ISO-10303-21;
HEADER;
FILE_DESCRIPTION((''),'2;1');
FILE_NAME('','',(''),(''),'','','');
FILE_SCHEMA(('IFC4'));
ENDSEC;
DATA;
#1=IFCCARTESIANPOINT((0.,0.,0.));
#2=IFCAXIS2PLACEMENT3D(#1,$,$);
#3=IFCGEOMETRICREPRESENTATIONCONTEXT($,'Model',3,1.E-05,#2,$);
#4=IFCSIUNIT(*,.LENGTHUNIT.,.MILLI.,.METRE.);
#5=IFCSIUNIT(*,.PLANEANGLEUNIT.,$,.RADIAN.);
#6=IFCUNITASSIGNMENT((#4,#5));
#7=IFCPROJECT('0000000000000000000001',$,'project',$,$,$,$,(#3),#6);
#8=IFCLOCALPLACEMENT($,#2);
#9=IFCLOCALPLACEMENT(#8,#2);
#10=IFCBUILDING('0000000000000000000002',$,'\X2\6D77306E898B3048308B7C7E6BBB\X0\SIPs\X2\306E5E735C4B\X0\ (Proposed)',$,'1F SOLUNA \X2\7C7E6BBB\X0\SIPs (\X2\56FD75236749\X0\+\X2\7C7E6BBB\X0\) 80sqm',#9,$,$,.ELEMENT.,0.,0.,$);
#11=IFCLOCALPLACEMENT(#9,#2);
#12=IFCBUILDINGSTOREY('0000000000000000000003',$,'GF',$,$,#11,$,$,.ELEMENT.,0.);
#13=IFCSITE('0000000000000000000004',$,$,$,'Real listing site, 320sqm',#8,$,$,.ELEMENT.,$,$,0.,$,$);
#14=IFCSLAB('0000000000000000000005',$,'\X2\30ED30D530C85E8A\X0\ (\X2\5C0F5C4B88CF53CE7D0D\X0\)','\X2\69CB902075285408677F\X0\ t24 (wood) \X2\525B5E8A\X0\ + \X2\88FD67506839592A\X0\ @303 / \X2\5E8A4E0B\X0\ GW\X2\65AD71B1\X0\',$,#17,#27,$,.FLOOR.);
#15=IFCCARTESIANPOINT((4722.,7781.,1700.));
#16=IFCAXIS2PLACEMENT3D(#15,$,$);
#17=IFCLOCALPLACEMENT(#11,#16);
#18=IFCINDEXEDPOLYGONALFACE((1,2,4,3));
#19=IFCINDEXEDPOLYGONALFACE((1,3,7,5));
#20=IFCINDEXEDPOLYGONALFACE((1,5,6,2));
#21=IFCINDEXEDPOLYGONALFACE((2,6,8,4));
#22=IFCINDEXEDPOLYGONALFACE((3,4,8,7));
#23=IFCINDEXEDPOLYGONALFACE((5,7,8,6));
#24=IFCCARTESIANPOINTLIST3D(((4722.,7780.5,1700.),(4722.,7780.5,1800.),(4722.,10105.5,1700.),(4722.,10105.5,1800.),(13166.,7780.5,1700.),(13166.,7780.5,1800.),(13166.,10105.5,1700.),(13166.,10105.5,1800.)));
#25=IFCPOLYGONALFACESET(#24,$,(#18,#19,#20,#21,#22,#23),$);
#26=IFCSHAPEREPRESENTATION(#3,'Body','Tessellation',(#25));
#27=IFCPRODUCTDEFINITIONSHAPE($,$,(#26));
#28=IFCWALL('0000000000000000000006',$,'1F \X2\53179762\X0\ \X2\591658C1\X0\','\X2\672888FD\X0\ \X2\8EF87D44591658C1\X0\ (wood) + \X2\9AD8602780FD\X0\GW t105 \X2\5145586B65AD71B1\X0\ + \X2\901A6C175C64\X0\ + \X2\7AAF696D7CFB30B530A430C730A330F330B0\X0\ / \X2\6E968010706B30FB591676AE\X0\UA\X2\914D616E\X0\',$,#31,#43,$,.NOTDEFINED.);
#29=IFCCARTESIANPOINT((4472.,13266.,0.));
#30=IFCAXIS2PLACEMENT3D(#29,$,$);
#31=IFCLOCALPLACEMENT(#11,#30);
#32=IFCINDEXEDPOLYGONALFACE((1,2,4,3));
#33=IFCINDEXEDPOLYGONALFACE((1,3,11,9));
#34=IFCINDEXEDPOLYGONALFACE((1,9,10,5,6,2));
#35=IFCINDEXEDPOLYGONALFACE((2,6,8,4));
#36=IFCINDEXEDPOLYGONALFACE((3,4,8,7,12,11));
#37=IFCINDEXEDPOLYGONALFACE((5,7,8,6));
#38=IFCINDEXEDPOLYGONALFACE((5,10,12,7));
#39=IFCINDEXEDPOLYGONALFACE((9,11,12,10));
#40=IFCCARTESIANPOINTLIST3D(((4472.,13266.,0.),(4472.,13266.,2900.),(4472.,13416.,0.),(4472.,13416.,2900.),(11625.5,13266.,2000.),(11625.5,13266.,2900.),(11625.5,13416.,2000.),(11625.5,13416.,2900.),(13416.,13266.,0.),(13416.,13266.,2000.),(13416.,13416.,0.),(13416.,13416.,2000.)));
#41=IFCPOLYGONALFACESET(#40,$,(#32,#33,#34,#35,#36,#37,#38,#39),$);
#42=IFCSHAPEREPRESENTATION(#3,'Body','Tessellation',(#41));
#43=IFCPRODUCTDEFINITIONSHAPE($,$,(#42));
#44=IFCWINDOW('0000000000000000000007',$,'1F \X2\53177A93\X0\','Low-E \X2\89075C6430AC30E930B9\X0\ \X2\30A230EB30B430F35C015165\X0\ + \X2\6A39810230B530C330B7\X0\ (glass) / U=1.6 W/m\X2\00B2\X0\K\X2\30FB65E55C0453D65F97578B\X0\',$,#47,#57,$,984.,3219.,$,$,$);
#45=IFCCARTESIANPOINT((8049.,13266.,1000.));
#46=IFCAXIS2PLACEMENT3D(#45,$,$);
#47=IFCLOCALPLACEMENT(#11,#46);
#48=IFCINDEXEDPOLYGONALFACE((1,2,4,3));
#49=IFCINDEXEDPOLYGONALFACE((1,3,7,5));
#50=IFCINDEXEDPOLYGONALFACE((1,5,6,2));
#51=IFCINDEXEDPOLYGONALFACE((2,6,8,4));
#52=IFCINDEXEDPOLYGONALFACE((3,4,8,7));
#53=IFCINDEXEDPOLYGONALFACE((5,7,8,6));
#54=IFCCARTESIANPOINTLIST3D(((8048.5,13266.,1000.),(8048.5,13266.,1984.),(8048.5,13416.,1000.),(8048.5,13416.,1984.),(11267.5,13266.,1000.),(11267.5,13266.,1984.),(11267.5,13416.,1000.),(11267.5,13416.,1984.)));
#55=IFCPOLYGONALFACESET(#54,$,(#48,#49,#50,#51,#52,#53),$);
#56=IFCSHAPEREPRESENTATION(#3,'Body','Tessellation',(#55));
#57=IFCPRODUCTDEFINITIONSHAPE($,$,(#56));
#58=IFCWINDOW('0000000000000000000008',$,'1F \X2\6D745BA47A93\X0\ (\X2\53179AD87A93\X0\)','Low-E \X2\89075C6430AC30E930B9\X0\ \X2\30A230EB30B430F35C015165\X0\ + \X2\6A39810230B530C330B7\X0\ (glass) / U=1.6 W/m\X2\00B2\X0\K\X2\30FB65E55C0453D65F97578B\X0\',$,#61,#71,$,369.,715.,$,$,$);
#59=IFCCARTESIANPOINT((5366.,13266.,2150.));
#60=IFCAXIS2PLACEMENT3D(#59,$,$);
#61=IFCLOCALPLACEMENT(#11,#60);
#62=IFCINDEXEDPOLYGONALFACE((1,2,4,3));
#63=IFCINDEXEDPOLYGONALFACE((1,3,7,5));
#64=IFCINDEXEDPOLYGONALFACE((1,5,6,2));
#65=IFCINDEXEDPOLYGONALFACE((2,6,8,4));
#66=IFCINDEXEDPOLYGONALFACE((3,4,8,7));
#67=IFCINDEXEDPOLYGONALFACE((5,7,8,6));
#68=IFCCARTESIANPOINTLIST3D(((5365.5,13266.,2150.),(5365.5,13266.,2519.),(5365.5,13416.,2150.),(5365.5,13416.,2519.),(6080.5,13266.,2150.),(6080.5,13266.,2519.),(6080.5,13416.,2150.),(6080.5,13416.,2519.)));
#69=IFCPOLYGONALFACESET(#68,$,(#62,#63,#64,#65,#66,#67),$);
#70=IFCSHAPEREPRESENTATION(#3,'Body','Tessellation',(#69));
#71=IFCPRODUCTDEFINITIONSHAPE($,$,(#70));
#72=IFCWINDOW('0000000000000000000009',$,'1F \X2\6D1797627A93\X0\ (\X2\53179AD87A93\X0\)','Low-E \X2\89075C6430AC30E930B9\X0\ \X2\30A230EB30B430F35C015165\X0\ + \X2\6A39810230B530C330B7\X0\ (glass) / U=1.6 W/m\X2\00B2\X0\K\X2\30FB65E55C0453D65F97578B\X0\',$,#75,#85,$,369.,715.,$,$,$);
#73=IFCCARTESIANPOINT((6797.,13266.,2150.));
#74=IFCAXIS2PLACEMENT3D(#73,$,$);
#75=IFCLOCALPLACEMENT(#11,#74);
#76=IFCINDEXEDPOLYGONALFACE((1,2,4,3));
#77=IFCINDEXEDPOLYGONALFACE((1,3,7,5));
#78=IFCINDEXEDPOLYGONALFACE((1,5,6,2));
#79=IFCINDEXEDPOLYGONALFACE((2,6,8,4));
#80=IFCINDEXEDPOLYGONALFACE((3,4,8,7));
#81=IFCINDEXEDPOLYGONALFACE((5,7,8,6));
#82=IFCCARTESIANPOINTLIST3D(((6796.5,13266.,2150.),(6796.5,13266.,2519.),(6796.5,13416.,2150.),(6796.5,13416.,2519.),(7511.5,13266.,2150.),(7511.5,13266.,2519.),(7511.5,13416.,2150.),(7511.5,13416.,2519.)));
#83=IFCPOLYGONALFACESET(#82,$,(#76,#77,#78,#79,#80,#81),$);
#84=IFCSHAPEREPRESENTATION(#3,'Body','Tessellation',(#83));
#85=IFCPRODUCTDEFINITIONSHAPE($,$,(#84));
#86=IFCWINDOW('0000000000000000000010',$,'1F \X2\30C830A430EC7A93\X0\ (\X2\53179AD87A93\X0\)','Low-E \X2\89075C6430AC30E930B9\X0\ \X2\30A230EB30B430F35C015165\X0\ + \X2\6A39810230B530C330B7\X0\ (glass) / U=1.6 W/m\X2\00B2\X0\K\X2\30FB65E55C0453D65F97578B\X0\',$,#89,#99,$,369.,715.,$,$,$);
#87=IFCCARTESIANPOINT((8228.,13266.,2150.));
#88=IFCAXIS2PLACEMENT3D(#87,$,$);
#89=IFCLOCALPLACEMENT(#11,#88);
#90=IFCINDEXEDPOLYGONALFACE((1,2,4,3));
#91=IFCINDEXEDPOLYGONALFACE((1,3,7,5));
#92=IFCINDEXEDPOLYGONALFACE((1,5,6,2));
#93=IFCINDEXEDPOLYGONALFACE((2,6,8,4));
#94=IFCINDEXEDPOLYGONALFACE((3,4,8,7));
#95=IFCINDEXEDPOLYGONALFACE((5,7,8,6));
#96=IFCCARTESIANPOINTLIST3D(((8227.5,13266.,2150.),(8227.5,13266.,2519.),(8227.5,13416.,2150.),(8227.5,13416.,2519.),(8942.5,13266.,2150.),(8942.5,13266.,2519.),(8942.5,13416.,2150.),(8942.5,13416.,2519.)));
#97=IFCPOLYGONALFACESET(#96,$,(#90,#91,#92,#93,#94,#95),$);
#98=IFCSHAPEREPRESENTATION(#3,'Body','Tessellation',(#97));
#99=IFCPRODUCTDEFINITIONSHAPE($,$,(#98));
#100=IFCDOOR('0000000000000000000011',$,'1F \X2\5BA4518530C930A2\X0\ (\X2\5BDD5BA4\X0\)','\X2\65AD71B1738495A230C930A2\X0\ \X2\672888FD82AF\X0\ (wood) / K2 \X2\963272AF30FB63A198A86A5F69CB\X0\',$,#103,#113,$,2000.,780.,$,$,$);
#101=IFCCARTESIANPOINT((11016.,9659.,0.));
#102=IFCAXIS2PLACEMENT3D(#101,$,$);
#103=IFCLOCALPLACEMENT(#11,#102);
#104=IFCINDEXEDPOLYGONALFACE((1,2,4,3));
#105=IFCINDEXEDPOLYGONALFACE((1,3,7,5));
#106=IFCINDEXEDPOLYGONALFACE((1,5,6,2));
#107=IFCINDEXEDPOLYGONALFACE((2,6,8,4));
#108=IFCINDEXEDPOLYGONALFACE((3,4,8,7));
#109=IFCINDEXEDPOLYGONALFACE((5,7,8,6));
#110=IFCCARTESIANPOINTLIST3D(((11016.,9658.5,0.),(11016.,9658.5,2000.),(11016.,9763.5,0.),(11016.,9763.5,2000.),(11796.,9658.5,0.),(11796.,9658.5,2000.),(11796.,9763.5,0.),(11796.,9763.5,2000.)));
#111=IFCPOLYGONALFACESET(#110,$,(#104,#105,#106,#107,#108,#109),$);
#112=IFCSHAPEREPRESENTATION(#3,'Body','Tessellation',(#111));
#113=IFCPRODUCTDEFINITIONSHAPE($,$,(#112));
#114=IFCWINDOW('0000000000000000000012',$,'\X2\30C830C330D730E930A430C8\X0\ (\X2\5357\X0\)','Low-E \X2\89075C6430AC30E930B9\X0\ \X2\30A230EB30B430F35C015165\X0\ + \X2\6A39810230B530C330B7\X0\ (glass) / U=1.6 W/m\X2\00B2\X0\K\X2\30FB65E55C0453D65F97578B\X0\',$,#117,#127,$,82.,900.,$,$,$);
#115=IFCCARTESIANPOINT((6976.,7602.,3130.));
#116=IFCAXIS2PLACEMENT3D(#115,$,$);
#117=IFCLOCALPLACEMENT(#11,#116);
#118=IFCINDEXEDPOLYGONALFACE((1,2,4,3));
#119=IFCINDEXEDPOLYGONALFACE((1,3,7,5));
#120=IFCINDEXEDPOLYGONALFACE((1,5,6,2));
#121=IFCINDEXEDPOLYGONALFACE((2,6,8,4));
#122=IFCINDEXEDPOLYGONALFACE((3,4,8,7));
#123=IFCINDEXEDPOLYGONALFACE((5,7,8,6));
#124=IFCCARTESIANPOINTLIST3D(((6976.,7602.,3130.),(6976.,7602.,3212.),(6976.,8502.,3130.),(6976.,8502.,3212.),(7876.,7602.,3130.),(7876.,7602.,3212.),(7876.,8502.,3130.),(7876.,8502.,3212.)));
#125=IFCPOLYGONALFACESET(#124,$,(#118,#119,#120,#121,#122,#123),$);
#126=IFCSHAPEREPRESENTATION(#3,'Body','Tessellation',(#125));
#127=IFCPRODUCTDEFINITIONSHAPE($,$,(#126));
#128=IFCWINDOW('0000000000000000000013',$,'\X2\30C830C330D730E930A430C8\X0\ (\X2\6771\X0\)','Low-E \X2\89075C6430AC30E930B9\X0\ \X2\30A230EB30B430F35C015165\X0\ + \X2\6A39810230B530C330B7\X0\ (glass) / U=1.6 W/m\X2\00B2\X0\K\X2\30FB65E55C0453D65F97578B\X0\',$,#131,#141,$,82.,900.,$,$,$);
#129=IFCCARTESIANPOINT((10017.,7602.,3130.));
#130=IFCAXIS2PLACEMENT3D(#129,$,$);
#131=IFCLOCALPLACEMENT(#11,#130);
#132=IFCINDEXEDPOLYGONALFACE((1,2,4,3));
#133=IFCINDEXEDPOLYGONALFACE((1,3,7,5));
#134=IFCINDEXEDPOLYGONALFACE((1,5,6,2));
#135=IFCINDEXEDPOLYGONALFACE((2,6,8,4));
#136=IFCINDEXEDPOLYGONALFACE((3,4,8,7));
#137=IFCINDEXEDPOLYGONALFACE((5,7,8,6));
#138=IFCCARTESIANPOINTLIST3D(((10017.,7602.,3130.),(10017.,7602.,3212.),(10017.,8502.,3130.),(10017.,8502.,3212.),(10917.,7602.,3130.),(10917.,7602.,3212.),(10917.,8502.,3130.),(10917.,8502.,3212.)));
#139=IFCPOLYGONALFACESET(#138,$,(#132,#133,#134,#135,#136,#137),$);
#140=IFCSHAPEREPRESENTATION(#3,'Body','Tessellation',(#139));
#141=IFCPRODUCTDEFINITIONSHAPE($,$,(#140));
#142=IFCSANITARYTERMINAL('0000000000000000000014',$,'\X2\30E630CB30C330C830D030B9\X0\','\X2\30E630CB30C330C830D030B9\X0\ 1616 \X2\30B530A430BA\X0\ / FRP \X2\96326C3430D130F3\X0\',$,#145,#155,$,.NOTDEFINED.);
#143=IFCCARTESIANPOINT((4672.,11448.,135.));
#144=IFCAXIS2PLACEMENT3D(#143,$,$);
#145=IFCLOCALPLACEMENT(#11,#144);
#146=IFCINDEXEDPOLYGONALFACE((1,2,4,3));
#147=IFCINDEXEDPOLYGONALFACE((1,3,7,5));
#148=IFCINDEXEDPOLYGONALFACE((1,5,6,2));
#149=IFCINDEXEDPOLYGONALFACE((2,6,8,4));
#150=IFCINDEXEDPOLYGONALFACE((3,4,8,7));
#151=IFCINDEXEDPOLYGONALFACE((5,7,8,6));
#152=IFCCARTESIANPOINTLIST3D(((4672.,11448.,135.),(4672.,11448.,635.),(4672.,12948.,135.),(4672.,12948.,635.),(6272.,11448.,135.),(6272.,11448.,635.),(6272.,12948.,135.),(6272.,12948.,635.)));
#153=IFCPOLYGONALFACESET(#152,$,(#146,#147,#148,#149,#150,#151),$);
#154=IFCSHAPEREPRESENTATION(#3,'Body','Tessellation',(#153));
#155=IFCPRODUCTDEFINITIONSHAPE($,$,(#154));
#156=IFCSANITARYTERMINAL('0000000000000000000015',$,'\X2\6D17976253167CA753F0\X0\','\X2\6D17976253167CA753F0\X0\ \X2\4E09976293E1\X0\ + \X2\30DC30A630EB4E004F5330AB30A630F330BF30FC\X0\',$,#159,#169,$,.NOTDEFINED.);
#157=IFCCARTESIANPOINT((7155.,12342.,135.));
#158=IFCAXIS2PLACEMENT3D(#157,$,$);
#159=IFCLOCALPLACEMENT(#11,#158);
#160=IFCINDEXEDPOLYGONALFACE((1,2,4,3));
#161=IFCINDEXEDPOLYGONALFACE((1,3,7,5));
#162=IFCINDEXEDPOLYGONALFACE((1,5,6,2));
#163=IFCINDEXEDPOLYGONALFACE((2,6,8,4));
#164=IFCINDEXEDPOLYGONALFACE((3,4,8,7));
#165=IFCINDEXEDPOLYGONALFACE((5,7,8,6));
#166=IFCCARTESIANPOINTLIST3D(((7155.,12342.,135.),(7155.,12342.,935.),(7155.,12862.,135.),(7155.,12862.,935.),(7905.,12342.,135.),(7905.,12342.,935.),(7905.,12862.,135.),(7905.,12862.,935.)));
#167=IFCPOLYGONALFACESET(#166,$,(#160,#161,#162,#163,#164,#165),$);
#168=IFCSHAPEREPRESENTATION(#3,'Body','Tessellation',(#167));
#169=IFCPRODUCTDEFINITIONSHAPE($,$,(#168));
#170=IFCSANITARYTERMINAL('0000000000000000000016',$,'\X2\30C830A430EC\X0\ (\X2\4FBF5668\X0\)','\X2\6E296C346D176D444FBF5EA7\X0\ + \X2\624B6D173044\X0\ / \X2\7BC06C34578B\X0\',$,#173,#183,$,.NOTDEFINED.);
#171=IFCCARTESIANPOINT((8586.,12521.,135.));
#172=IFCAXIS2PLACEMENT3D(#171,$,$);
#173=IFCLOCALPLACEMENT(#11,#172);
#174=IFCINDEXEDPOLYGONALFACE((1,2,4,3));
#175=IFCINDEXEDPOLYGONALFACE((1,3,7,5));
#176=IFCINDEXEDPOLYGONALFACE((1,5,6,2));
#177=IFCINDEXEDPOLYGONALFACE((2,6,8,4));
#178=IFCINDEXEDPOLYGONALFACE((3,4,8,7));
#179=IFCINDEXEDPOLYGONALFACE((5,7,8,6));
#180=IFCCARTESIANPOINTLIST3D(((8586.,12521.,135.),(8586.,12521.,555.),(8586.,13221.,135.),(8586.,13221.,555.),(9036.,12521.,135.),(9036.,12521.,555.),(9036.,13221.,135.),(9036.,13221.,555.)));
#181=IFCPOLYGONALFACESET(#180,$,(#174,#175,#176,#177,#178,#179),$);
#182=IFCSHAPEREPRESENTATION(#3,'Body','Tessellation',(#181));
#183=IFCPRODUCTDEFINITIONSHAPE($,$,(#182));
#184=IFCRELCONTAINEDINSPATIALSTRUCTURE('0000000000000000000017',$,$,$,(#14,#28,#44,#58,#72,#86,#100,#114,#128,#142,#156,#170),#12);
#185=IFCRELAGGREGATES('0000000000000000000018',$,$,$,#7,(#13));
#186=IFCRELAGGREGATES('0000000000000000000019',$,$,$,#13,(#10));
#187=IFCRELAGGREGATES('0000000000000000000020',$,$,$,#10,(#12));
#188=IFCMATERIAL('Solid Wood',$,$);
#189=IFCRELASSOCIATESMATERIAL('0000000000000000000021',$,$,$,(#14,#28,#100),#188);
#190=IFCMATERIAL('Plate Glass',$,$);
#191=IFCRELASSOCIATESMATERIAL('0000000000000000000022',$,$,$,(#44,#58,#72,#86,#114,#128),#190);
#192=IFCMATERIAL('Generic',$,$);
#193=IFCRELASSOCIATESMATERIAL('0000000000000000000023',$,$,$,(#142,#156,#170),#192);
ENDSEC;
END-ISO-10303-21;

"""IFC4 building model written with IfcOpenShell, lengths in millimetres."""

from ifc_helpers import new_model, si_unit, frame, frame_2d, origin, place, context, project, spatial, rectangle, extrude, material, element, fill, save


model = new_model("IFC4")

# Units and contexts
model_context = context("Model", 3, precision=1e-05, world=origin())
ifc_project = project(units=[si_unit("LENGTHUNIT", "METRE", prefix="MILLI"), si_unit("PLANEANGLEUNIT", "RADIAN")], contexts=[model_context])

# Site, building, storey
site_placement = place(None, origin())
site = spatial("IfcSite", under=ifc_project, at=site_placement, ObjectType="Real listing site, 320sqm", CompositionType="ELEMENT", RefElevation=0.0)
building_placement = place(site_placement, origin())
building = spatial("IfcBuilding", under=site, at=building_placement, Name="海の見える籾殻SIPsの平屋 (Proposed)", ObjectType="1F SOLUNA 籾殻SIPs (国産杉+籾殻) 80sqm", CompositionType="ELEMENT", ElevationOfRefHeight=0.0, ElevationOfTerrain=0.0)
storey_placement = place(building_placement, origin())
storey = spatial("IfcBuildingStorey", under=building, at=storey_placement, Name="GF", CompositionType="ELEMENT", Elevation=0.0)

# Slab
ifc_material_1 = material(Name="Solid Wood")
slab_placement = place(storey_placement, frame((4722.0, 7781.0, 1700.0)))
element("IfcSlab", 1, at=slab_placement, inside=storey, material=ifc_material_1, Name="ロフト床 (小屋裏収納)", Description="構造用合板 t24 (wood) 剛床 + 製材根太 @303 / 床下 GW断熱", PredefinedType="FLOOR", context=model_context, shape_type="SweptSolid", body=[
    extrude(rectangle(XDim=8444.0, YDim=2325.0, at=frame_2d((4222.0, 1162.0))), frame((4722.0, 7781.0, 1700.0)), (0.0, 0.0, 1.0), 100.0),
])

# Wall, openings, windows
wall_1_placement = place(storey_placement, frame((4472.0, 13266.0, 0.0)))
wall_1 = element("IfcWall", 2, at=wall_1_placement, inside=storey, material=ifc_material_1, Name="1F 北面 外壁", Description="木製 軸組外壁 (wood) + 高性能GW t105 充填断熱 + 通気層 + 窯業系サイディング / 準耐火・外皮UA配慮", PredefinedType="NOTDEFINED", context=model_context, shape_type="SweptSolid", body=[
    extrude(rectangle(XDim=8944.0, YDim=150.0, at=frame_2d((4472.0, 75.0))), frame((4472.0, 13266.0, 0.0)), (0.0, 0.0, 1.0), 2900.0),
])
opening_1_placement = place(storey_placement, frame((8049.0, 13266.0, 1000.0)))
opening_1 = element("IfcOpeningElement", 3, at=opening_1_placement, cuts=wall_1, PredefinedType="NOTDEFINED", context=model_context, shape_type="SweptSolid", body=[
    extrude(rectangle(XDim=3219.0, YDim=150.0, at=frame_2d((1609.0, 75.0))), frame((8049.0, 13266.0, 1000.0)), (0.0, 0.0, 1.0), 984.0),
])
opening_2_placement = place(storey_placement, frame((5366.0, 13266.0, 2150.0)))
opening_2 = element("IfcOpeningElement", 4, at=opening_2_placement, cuts=wall_1, PredefinedType="NOTDEFINED", context=model_context, shape_type="SweptSolid", body=[
    extrude(rectangle(XDim=715.0, YDim=150.0, at=frame_2d((357.0, 75.0))), frame((5366.0, 13266.0, 2150.0)), (0.0, 0.0, 1.0), 369.0),
])
opening_3_placement = place(storey_placement, frame((6797.0, 13266.0, 2150.0)))
opening_3 = element("IfcOpeningElement", 5, at=opening_3_placement, cuts=wall_1, PredefinedType="NOTDEFINED", context=model_context, shape_type="SweptSolid", body=[
    extrude(rectangle(XDim=715.0, YDim=150.0, at=frame_2d((357.0, 75.0))), frame((6797.0, 13266.0, 2150.0)), (0.0, 0.0, 1.0), 369.0),
])
opening_4_placement = place(storey_placement, frame((8228.0, 13266.0, 2150.0)))
opening_4 = element("IfcOpeningElement", 6, at=opening_4_placement, cuts=wall_1, PredefinedType="NOTDEFINED", context=model_context, shape_type="SweptSolid", body=[
    extrude(rectangle(XDim=715.0, YDim=150.0, at=frame_2d((357.0, 75.0))), frame((8228.0, 13266.0, 2150.0)), (0.0, 0.0, 1.0), 369.0),
])
ifc_material_2 = material(Name="Plate Glass")
window_1_placement = place(storey_placement, frame((8049.0, 13266.0, 1000.0)))
window_1 = element("IfcWindow", 7, at=window_1_placement, inside=storey, material=ifc_material_2, Name="1F 北窓", Description="Low-E 複層ガラス アルゴン封入 + 樹脂サッシ (glass) / U=1.6 W/m²K・日射取得型", OverallHeight=984.0, OverallWidth=3219.0, context=model_context, shape_type="SweptSolid", body=[
    extrude(rectangle(XDim=3219.0, YDim=150.0, at=frame_2d((1609.0, 75.0))), frame((8049.0, 13266.0, 1000.0)), (0.0, 0.0, 1.0), 984.0),
])
fill(opening_1, window_1)
window_2_placement = place(storey_placement, frame((5366.0, 13266.0, 2150.0)))
window_2 = element("IfcWindow", 8, at=window_2_placement, inside=storey, material=ifc_material_2, Name="1F 浴室窓 (北高窓)", Description="Low-E 複層ガラス アルゴン封入 + 樹脂サッシ (glass) / U=1.6 W/m²K・日射取得型", OverallHeight=369.0, OverallWidth=715.0, context=model_context, shape_type="SweptSolid", body=[
    extrude(rectangle(XDim=715.0, YDim=150.0, at=frame_2d((357.0, 75.0))), frame((5366.0, 13266.0, 2150.0)), (0.0, 0.0, 1.0), 369.0),
])
fill(opening_2, window_2)
window_3_placement = place(storey_placement, frame((6797.0, 13266.0, 2150.0)))
window_3 = element("IfcWindow", 9, at=window_3_placement, inside=storey, material=ifc_material_2, Name="1F 洗面窓 (北高窓)", Description="Low-E 複層ガラス アルゴン封入 + 樹脂サッシ (glass) / U=1.6 W/m²K・日射取得型", OverallHeight=369.0, OverallWidth=715.0, context=model_context, shape_type="SweptSolid", body=[
    extrude(rectangle(XDim=715.0, YDim=150.0, at=frame_2d((357.0, 75.0))), frame((6797.0, 13266.0, 2150.0)), (0.0, 0.0, 1.0), 369.0),
])
fill(opening_3, window_3)
window_4_placement = place(storey_placement, frame((8228.0, 13266.0, 2150.0)))
window_4 = element("IfcWindow", 10, at=window_4_placement, inside=storey, material=ifc_material_2, Name="1F トイレ窓 (北高窓)", Description="Low-E 複層ガラス アルゴン封入 + 樹脂サッシ (glass) / U=1.6 W/m²K・日射取得型", OverallHeight=369.0, OverallWidth=715.0, context=model_context, shape_type="SweptSolid", body=[
    extrude(rectangle(XDim=715.0, YDim=150.0, at=frame_2d((357.0, 75.0))), frame((8228.0, 13266.0, 2150.0)), (0.0, 0.0, 1.0), 369.0),
])
fill(opening_4, window_4)

# Door
door_1_placement = place(storey_placement, frame((11016.0, 9659.0, 0.0)))
element("IfcDoor", 11, at=door_1_placement, inside=storey, material=ifc_material_1, Name="1F 室内ドア (寝室)", Description="断熱玄関ドア 木製芯 (wood) / K2 防犯・採風機構", OverallHeight=2000.0, OverallWidth=780.0, context=model_context, shape_type="SweptSolid", body=[
    extrude(rectangle(XDim=780.0, YDim=105.0, at=frame_2d((390.0, 52.0))), frame((11016.0, 9659.0, 0.0)), (0.0, 0.0, 1.0), 2000.0),
])

# Windows
window_5_placement = place(storey_placement, frame((6976.0, 7602.0, 3130.0)))
element("IfcWindow", 12, at=window_5_placement, inside=storey, material=ifc_material_2, Name="トップライト (南)", Description="Low-E 複層ガラス アルゴン封入 + 樹脂サッシ (glass) / U=1.6 W/m²K・日射取得型", OverallHeight=82.0, OverallWidth=900.0, context=model_context, shape_type="SweptSolid", body=[
    extrude(rectangle(XDim=900.0, YDim=900.0, at=frame_2d((450.0, 450.0))), frame((6976.0, 7602.0, 3130.0)), (0.0, 0.0, 1.0), 82.0),
])
window_6_placement = place(storey_placement, frame((10017.0, 7602.0, 3130.0)))
element("IfcWindow", 13, at=window_6_placement, inside=storey, material=ifc_material_2, Name="トップライト (東)", Description="Low-E 複層ガラス アルゴン封入 + 樹脂サッシ (glass) / U=1.6 W/m²K・日射取得型", OverallHeight=82.0, OverallWidth=900.0, context=model_context, shape_type="SweptSolid", body=[
    extrude(rectangle(XDim=900.0, YDim=900.0, at=frame_2d((450.0, 450.0))), frame((10017.0, 7602.0, 3130.0)), (0.0, 0.0, 1.0), 82.0),
])

# Sanitary terminals
ifc_material_3 = material(Name="Generic")
sanitary_terminal_1_placement = place(storey_placement, frame((4672.0, 11448.0, 135.0)))
element("IfcSanitaryTerminal", 14, at=sanitary_terminal_1_placement, inside=storey, material=ifc_material_3, Name="ユニットバス", Description="ユニットバス 1616 サイズ / FRP 防水パン", PredefinedType="NOTDEFINED", context=model_context, shape_type="SweptSolid", body=[
    extrude(rectangle(XDim=1600.0, YDim=1500.0, at=frame_2d((800.0, 750.0))), frame((4672.0, 11448.0, 135.0)), (0.0, 0.0, 1.0), 500.0),
])
sanitary_terminal_2_placement = place(storey_placement, frame((7155.0, 12342.0, 135.0)))
element("IfcSanitaryTerminal", 15, at=sanitary_terminal_2_placement, inside=storey, material=ifc_material_3, Name="洗面化粧台", Description="洗面化粧台 三面鏡 + ボウル一体カウンター", PredefinedType="NOTDEFINED", context=model_context, shape_type="SweptSolid", body=[
    extrude(rectangle(XDim=750.0, YDim=520.0, at=frame_2d((375.0, 260.0))), frame((7155.0, 12342.0, 135.0)), (0.0, 0.0, 1.0), 800.0),
])
sanitary_terminal_3_placement = place(storey_placement, frame((8586.0, 12521.0, 135.0)))
element("IfcSanitaryTerminal", 16, at=sanitary_terminal_3_placement, inside=storey, material=ifc_material_3, Name="トイレ (便器)", Description="温水洗浄便座 + 手洗い / 節水型", PredefinedType="NOTDEFINED", context=model_context, shape_type="SweptSolid", body=[
    extrude(rectangle(XDim=450.0, YDim=700.0, at=frame_2d((225.0, 350.0))), frame((8586.0, 12521.0, 135.0)), (0.0, 0.0, 1.0), 420.0),
])

save(model, "model.ifc")
